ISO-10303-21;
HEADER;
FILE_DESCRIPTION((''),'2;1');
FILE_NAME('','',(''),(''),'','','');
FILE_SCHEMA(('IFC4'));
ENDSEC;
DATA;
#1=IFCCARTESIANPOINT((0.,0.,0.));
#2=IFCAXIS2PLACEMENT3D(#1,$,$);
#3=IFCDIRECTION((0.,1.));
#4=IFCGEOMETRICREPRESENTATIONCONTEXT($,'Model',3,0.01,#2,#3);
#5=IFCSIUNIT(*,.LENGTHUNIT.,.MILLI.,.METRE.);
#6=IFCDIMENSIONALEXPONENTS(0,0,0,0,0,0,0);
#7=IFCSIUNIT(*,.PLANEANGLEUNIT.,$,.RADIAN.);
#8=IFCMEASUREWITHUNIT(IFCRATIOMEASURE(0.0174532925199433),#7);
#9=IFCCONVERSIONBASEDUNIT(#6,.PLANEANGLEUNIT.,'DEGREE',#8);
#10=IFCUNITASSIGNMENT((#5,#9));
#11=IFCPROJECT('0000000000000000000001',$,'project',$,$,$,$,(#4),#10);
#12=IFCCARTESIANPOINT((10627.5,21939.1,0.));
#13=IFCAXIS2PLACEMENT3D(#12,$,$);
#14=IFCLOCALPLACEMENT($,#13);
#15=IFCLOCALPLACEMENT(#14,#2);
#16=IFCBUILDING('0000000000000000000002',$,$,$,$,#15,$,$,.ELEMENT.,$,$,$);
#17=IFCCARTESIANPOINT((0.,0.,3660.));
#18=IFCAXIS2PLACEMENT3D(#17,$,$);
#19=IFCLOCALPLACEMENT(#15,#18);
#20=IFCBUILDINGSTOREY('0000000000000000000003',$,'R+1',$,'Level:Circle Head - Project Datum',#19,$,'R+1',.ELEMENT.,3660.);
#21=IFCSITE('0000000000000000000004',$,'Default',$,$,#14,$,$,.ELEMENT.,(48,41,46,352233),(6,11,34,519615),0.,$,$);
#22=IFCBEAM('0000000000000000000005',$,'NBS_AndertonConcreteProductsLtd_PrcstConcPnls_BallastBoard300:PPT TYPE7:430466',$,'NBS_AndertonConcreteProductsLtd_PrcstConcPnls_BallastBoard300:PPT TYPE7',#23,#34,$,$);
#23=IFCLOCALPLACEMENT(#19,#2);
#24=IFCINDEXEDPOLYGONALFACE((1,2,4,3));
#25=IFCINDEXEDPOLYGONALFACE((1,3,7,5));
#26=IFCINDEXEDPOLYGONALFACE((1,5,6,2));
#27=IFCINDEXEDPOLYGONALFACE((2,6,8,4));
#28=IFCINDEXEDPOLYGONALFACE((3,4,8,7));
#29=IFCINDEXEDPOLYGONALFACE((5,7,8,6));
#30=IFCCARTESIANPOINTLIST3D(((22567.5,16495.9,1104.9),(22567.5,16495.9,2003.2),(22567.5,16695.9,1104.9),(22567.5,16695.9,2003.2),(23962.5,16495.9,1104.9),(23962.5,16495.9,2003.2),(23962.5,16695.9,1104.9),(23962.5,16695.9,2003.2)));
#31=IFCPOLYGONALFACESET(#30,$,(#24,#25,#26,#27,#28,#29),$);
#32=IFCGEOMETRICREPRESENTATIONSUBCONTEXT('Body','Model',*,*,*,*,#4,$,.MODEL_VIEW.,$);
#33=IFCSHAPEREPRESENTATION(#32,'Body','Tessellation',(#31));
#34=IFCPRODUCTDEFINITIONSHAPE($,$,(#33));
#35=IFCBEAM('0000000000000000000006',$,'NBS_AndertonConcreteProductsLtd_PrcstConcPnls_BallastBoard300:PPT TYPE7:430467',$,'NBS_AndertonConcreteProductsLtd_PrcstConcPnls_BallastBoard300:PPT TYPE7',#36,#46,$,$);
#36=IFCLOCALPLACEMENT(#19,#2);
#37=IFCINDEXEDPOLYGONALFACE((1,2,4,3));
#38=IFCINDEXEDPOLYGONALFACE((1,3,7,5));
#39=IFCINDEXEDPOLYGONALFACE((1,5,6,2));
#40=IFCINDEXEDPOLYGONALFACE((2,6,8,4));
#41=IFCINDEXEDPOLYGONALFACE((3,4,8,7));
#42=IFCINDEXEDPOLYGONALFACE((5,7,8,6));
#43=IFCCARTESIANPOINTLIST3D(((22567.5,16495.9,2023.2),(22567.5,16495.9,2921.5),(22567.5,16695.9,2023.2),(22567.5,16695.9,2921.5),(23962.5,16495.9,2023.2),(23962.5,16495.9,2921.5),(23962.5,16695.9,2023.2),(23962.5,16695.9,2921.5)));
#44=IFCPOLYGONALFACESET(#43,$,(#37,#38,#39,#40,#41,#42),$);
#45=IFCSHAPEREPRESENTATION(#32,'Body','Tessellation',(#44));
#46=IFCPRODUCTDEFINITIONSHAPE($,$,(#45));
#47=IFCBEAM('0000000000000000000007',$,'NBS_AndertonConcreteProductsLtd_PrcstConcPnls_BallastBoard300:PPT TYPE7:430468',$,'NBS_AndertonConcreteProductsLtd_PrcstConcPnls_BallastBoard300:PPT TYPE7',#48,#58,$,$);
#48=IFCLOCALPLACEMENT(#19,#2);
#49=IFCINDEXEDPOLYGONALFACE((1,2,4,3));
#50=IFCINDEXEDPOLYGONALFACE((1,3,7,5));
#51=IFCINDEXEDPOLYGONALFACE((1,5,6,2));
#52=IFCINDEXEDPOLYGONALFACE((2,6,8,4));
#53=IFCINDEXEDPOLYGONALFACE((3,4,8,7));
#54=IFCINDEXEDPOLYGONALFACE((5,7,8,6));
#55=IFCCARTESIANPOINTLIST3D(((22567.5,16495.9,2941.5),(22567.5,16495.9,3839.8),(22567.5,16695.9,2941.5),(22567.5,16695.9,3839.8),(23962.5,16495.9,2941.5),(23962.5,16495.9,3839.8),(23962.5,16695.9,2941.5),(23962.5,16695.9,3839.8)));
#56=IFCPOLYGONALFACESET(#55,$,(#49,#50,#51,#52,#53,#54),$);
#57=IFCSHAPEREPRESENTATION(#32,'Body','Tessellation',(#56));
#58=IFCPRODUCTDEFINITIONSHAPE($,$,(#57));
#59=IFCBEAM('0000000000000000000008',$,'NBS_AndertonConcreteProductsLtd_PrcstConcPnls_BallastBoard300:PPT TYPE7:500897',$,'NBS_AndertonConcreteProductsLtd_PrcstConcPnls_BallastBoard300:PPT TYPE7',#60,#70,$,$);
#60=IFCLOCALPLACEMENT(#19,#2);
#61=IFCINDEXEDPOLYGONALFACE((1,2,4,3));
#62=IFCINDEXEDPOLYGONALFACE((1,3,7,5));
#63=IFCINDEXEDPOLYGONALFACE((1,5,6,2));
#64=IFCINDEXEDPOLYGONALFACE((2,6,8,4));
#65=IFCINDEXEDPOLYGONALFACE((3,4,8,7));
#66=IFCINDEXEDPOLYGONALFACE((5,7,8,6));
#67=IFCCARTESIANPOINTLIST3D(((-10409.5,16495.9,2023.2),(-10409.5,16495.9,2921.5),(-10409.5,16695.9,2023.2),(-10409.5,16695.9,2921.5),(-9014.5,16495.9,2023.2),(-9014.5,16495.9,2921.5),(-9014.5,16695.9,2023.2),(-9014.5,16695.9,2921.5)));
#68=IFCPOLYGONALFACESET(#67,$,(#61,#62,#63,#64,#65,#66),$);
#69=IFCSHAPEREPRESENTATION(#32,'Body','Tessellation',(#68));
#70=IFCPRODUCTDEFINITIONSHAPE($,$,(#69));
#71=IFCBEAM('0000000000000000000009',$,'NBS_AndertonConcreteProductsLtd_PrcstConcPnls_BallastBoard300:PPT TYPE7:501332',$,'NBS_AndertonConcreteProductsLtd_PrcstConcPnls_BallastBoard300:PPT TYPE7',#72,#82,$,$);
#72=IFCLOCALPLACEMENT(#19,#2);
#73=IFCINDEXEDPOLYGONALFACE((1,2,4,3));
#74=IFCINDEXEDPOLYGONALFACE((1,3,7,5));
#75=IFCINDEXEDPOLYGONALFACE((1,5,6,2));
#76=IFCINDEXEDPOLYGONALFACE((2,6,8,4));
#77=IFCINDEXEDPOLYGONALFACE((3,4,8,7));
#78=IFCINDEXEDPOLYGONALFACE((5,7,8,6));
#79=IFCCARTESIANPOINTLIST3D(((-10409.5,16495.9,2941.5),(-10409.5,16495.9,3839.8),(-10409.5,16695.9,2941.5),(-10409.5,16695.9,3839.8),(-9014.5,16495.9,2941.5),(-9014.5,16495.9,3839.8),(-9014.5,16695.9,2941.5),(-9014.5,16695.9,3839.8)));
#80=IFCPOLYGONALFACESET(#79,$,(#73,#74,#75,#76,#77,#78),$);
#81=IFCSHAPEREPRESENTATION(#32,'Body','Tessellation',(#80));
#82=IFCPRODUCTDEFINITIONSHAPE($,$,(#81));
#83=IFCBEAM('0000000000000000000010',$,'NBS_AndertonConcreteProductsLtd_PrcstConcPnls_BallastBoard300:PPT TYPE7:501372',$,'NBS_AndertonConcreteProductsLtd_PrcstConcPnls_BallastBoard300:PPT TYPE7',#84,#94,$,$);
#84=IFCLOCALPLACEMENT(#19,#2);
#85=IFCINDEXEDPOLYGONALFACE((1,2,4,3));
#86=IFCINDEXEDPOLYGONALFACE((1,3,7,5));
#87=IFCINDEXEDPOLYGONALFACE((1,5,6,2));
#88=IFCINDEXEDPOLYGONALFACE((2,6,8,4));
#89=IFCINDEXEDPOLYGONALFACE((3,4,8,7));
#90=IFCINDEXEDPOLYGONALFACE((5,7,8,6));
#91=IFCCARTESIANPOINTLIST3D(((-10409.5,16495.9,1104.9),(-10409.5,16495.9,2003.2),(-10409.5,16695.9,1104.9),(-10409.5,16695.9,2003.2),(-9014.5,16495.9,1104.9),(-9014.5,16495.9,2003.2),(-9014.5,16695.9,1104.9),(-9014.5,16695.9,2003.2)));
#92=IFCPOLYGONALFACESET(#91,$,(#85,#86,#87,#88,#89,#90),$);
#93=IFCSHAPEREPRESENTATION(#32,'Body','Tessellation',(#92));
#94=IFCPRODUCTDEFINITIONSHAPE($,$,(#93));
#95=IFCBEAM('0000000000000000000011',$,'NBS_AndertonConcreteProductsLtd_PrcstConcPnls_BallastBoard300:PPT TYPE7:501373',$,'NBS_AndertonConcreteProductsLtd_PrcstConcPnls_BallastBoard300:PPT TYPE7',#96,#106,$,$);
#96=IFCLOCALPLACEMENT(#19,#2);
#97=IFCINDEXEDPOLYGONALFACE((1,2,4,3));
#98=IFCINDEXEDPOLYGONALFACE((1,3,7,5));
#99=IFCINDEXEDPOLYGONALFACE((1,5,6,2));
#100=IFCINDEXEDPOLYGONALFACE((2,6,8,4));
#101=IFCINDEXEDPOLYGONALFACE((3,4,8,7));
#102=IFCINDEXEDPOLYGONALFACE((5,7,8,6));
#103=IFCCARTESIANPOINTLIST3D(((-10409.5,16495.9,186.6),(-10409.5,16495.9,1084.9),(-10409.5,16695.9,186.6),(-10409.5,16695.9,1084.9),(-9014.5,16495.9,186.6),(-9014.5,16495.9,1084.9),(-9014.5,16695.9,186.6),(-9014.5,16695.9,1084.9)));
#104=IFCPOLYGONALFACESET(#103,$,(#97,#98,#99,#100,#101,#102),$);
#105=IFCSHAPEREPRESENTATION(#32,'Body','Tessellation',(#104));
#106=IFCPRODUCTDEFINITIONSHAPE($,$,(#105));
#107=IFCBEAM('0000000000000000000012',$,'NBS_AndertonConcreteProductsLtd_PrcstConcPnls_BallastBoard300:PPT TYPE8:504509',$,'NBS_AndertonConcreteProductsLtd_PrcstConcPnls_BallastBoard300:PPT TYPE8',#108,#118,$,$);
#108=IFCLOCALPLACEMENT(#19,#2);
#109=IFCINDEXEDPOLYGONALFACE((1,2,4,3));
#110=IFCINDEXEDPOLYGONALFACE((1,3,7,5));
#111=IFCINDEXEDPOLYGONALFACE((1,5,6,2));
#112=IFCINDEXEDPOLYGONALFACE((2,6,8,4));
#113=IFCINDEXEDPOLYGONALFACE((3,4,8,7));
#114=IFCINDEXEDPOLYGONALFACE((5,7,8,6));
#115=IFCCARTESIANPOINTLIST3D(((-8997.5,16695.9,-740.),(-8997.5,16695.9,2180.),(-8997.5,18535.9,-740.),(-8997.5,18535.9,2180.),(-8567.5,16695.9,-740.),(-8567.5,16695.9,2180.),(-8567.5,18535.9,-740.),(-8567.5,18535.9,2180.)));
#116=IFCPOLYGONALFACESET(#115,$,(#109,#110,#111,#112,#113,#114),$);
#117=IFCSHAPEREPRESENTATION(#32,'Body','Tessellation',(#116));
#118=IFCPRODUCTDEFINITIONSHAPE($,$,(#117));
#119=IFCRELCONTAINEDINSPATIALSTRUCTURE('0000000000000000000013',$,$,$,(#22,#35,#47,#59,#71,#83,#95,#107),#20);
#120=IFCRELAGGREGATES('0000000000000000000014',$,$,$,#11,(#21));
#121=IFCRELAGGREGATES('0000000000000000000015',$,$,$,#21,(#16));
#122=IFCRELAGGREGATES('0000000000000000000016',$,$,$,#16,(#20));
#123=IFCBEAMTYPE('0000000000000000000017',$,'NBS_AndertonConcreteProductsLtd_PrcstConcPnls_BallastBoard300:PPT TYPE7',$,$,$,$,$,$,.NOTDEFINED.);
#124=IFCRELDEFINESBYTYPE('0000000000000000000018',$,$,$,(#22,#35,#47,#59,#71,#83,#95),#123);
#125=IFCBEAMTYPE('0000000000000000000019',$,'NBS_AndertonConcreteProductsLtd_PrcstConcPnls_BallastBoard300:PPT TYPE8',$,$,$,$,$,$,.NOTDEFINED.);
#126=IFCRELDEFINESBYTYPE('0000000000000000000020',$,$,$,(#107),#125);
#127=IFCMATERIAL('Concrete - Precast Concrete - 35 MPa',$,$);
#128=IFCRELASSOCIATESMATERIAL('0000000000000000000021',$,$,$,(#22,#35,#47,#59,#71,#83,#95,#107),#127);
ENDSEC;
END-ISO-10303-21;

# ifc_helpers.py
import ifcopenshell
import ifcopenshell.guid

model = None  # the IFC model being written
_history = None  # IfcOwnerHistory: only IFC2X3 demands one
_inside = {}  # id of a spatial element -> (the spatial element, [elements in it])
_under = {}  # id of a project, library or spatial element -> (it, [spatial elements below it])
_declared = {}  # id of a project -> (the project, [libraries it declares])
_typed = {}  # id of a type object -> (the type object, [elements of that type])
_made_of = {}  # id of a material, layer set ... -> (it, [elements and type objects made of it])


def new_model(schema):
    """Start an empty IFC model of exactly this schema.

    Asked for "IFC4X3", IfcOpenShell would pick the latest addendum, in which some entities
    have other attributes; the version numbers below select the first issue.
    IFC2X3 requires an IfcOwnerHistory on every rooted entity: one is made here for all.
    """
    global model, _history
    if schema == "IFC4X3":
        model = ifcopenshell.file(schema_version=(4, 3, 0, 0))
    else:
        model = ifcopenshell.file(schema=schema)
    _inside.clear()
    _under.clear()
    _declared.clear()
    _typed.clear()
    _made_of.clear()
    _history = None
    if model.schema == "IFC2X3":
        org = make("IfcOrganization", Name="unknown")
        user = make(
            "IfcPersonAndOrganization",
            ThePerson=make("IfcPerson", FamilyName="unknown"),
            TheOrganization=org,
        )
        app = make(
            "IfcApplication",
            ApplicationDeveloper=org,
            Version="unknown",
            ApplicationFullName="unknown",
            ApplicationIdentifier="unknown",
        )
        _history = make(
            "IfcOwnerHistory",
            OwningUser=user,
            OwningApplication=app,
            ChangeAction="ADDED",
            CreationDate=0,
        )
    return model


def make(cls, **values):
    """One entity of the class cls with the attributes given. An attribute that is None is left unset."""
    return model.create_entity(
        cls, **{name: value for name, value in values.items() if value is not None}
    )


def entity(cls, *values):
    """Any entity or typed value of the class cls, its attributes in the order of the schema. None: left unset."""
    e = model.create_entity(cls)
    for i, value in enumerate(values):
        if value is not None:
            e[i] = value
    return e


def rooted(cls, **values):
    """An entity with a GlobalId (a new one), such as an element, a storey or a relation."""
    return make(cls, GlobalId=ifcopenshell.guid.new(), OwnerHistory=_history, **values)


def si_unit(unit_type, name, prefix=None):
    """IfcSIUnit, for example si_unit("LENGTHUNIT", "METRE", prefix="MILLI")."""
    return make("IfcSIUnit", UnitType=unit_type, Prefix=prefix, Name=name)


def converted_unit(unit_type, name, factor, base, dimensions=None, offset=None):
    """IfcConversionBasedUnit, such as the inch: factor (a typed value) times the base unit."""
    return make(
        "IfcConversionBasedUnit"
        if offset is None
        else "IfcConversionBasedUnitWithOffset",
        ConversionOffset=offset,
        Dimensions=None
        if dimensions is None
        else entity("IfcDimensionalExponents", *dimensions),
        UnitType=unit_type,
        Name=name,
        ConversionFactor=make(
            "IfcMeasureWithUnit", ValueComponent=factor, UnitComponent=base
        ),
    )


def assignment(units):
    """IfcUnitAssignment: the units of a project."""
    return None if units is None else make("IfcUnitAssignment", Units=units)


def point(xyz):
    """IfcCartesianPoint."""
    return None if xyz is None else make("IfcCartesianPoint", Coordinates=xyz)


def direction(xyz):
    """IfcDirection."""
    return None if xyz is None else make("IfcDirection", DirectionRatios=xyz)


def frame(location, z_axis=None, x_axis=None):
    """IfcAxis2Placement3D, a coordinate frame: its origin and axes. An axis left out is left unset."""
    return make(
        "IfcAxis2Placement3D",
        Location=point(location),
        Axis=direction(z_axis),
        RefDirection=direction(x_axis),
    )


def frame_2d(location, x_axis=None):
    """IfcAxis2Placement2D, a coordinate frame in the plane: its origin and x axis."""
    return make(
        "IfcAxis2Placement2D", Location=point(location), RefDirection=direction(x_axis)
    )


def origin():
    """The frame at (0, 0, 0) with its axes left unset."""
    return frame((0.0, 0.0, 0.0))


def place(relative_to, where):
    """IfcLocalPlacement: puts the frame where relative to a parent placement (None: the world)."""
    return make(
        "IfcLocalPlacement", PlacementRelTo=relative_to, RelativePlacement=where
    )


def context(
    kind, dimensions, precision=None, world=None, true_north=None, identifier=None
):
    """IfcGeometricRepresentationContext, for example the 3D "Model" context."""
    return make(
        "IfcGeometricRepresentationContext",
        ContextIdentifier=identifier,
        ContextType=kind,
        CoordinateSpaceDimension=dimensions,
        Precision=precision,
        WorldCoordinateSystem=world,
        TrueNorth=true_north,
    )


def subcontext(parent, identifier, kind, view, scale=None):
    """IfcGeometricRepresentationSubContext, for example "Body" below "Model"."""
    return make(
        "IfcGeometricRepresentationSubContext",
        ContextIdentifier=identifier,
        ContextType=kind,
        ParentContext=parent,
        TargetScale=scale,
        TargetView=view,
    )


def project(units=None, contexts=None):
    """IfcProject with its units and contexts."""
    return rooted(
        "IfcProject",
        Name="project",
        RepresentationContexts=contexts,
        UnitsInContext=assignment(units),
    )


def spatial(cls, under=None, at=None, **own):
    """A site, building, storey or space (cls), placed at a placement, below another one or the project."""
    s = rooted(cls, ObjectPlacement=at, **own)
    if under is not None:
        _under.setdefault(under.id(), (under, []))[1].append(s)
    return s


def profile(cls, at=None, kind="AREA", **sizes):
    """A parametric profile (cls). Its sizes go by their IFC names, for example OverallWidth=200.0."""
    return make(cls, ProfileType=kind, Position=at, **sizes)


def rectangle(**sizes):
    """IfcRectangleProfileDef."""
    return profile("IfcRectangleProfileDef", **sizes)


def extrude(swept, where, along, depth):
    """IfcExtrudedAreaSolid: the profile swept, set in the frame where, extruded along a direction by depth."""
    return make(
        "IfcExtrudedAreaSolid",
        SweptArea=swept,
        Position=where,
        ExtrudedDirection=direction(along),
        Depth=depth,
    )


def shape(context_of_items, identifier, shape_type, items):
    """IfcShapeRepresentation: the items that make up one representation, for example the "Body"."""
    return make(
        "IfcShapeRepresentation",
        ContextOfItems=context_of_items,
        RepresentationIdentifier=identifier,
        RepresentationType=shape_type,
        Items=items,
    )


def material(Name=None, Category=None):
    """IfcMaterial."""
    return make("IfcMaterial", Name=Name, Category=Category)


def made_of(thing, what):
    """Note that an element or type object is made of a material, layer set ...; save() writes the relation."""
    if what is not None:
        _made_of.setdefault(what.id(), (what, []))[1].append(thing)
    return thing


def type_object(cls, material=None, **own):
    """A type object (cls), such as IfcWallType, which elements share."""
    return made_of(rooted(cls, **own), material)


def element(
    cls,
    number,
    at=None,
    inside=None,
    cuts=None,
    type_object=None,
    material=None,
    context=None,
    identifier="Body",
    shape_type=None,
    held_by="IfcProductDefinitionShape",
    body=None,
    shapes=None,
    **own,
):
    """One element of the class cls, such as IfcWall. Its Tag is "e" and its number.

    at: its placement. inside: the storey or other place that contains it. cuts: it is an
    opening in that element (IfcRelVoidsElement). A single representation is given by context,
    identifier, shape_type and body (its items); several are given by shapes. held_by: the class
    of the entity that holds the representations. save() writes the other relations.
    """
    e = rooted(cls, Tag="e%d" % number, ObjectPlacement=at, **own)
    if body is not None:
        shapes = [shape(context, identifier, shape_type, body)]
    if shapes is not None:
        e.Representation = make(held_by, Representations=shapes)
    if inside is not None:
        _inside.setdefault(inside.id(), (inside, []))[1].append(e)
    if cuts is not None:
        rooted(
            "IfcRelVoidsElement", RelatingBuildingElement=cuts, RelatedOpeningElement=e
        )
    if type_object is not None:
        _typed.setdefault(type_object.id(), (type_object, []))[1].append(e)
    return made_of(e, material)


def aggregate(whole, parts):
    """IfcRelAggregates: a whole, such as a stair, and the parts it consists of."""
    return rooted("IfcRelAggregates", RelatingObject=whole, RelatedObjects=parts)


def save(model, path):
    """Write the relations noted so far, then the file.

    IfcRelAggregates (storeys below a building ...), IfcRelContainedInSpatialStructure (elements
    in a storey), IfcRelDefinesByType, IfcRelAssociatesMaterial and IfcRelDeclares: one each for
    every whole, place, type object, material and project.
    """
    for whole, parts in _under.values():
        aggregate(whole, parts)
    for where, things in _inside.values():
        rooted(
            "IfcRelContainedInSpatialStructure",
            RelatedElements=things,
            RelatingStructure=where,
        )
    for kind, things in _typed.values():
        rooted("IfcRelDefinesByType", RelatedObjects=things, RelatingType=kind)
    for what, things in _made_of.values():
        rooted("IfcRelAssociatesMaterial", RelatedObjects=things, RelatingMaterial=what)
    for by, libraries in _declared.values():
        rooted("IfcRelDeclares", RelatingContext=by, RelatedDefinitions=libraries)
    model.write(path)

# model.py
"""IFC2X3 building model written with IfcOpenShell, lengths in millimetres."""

from ifc_helpers import new_model, entity, si_unit, converted_unit, direction, frame, frame_2d, origin, place, context, subcontext, project, spatial, rectangle, extrude, material, type_object, element, save


model = new_model("IFC2X3")

# Units and contexts
model_context = context("Model", 3, precision=0.01, world=origin(), true_north=direction((0.0, 1.0)))
body_context = subcontext(model_context, "Body", "Model", "MODEL_VIEW")
ifc_project = project(units=[si_unit("LENGTHUNIT", "METRE", prefix="MILLI"), converted_unit("PLANEANGLEUNIT", "DEGREE", entity("IfcRatioMeasure", 0.0174532925199433), si_unit("PLANEANGLEUNIT", "RADIAN"), dimensions=[0, 0, 0, 0, 0, 0, 0])], contexts=[model_context])

# Site, building, storey
site_placement = place(None, frame((10627.5, 21939.1, 0.0)))
site = spatial("IfcSite", under=ifc_project, at=site_placement, Name="Default", CompositionType="ELEMENT", RefLatitude=(48, 41, 46, 352233), RefLongitude=(6, 11, 34, 519615), RefElevation=0.0)
building_placement = place(site_placement, origin())
building = spatial("IfcBuilding", under=site, at=building_placement, CompositionType="ELEMENT")
storey_placement = place(building_placement, frame((0.0, 0.0, 3660.0)))
storey = spatial("IfcBuildingStorey", under=building, at=storey_placement, Name="R+1", ObjectType="Level:Circle Head - Project Datum", LongName="R+1", CompositionType="ELEMENT", Elevation=3660.0)

# Beams
ifc_material_1 = material(Name="Concrete - Precast Concrete - 35 MPa")
beam_type_1 = type_object("IfcBeamType", Name="NBS_AndertonConcreteProductsLtd_PrcstConcPnls_BallastBoard300:PPT TYPE7", PredefinedType="NOTDEFINED")
beam_1_placement = place(storey_placement, origin())
element("IfcBeam", 1, at=beam_1_placement, inside=storey, type_object=beam_type_1, material=ifc_material_1, Name="NBS_AndertonConcreteProductsLtd_PrcstConcPnls_BallastBoard300:PPT TYPE7:430466", ObjectType="NBS_AndertonConcreteProductsLtd_PrcstConcPnls_BallastBoard300:PPT TYPE7", context=body_context, shape_type="SweptSolid", body=[
    extrude(rectangle(XDim=898.3, YDim=200.0, at=frame_2d((0.0, 0.0), x_axis=(0.0, 1.0))), frame((22567.5, 16595.9, 1554.1), z_axis=(1.0, 0.0, 0.0), x_axis=(0.0, 1.0, 0.0)), (0.0, 0.0, 1.0), 1395.0),
])
beam_2_placement = place(storey_placement, origin())
element("IfcBeam", 2, at=beam_2_placement, inside=storey, type_object=beam_type_1, material=ifc_material_1, Name="NBS_AndertonConcreteProductsLtd_PrcstConcPnls_BallastBoard300:PPT TYPE7:430467", ObjectType="NBS_AndertonConcreteProductsLtd_PrcstConcPnls_BallastBoard300:PPT TYPE7", context=body_context, shape_type="SweptSolid", body=[
    extrude(rectangle(XDim=898.3, YDim=200.0, at=frame_2d((0.0, 0.0), x_axis=(0.0, 1.0))), frame((22567.5, 16595.9, 2472.4), z_axis=(1.0, 0.0, 0.0), x_axis=(0.0, 1.0, 0.0)), (0.0, 0.0, 1.0), 1395.0),
])
beam_3_placement = place(storey_placement, origin())
element("IfcBeam", 3, at=beam_3_placement, inside=storey, type_object=beam_type_1, material=ifc_material_1, Name="NBS_AndertonConcreteProductsLtd_PrcstConcPnls_BallastBoard300:PPT TYPE7:430468", ObjectType="NBS_AndertonConcreteProductsLtd_PrcstConcPnls_BallastBoard300:PPT TYPE7", context=body_context, shape_type="SweptSolid", body=[
    extrude(rectangle(XDim=898.3, YDim=200.0, at=frame_2d((0.0, 0.0), x_axis=(0.0, 1.0))), frame((22567.5, 16595.9, 3390.7), z_axis=(1.0, 0.0, 0.0), x_axis=(0.0, 1.0, 0.0)), (0.0, 0.0, 1.0), 1395.0),
])
beam_4_placement = place(storey_placement, origin())
element("IfcBeam", 4, at=beam_4_placement, inside=storey, type_object=beam_type_1, material=ifc_material_1, Name="NBS_AndertonConcreteProductsLtd_PrcstConcPnls_BallastBoard300:PPT TYPE7:500897", ObjectType="NBS_AndertonConcreteProductsLtd_PrcstConcPnls_BallastBoard300:PPT TYPE7", context=body_context, shape_type="SweptSolid", body=[
    extrude(rectangle(XDim=898.3, YDim=200.0, at=frame_2d((0.0, 0.0), x_axis=(0.0, 1.0))), frame((-10409.5, 16595.9, 2472.4), z_axis=(1.0, 0.0, 0.0), x_axis=(0.0, 1.0, 0.0)), (0.0, 0.0, 1.0), 1395.0),
])
beam_5_placement = place(storey_placement, origin())
element("IfcBeam", 5, at=beam_5_placement, inside=storey, type_object=beam_type_1, material=ifc_material_1, Name="NBS_AndertonConcreteProductsLtd_PrcstConcPnls_BallastBoard300:PPT TYPE7:501332", ObjectType="NBS_AndertonConcreteProductsLtd_PrcstConcPnls_BallastBoard300:PPT TYPE7", context=body_context, shape_type="SweptSolid", body=[
    extrude(rectangle(XDim=898.3, YDim=200.0, at=frame_2d((0.0, 0.0), x_axis=(0.0, 1.0))), frame((-10409.5, 16595.9, 3390.7), z_axis=(1.0, 0.0, 0.0), x_axis=(0.0, 1.0, 0.0)), (0.0, 0.0, 1.0), 1395.0),
])
beam_6_placement = place(storey_placement, origin())
element("IfcBeam", 6, at=beam_6_placement, inside=storey, type_object=beam_type_1, material=ifc_material_1, Name="NBS_AndertonConcreteProductsLtd_PrcstConcPnls_BallastBoard300:PPT TYPE7:501372", ObjectType="NBS_AndertonConcreteProductsLtd_PrcstConcPnls_BallastBoard300:PPT TYPE7", context=body_context, shape_type="SweptSolid", body=[
    extrude(rectangle(XDim=898.3, YDim=200.0, at=frame_2d((0.0, 0.0), x_axis=(0.0, 1.0))), frame((-10409.5, 16595.9, 1554.0), z_axis=(1.0, 0.0, 0.0), x_axis=(0.0, 1.0, 0.0)), (0.0, 0.0, 1.0), 1395.0),
])
beam_7_placement = place(storey_placement, origin())
element("IfcBeam", 7, at=beam_7_placement, inside=storey, type_object=beam_type_1, material=ifc_material_1, Name="NBS_AndertonConcreteProductsLtd_PrcstConcPnls_BallastBoard300:PPT TYPE7:501373", ObjectType="NBS_AndertonConcreteProductsLtd_PrcstConcPnls_BallastBoard300:PPT TYPE7", context=body_context, shape_type="SweptSolid", body=[
    extrude(rectangle(XDim=898.3, YDim=200.0, at=frame_2d((0.0, 0.0), x_axis=(0.0, 1.0))), frame((-10409.5, 16595.9, 635.7), z_axis=(1.0, 0.0, 0.0), x_axis=(0.0, 1.0, 0.0)), (0.0, 0.0, 1.0), 1395.0),
])
beam_type_2 = type_object("IfcBeamType", Name="NBS_AndertonConcreteProductsLtd_PrcstConcPnls_BallastBoard300:PPT TYPE8", PredefinedType="NOTDEFINED")
beam_8_placement = place(storey_placement, origin())
element("IfcBeam", 8, at=beam_8_placement, inside=storey, type_object=beam_type_2, material=ifc_material_1, Name="NBS_AndertonConcreteProductsLtd_PrcstConcPnls_BallastBoard300:PPT TYPE8:504509", ObjectType="NBS_AndertonConcreteProductsLtd_PrcstConcPnls_BallastBoard300:PPT TYPE8", context=body_context, shape_type="SweptSolid", body=[
    extrude(rectangle(XDim=2920.0, YDim=1840.0, at=frame_2d((0.0, 0.0), x_axis=(0.0, 1.0))), frame((-8997.5, 17615.9, 720.0), z_axis=(1.0, 0.0, 0.0), x_axis=(0.0, -1.0, 0.0)), (0.0, 0.0, 1.0), 430.0),
])

save(model, "model.ifc")
